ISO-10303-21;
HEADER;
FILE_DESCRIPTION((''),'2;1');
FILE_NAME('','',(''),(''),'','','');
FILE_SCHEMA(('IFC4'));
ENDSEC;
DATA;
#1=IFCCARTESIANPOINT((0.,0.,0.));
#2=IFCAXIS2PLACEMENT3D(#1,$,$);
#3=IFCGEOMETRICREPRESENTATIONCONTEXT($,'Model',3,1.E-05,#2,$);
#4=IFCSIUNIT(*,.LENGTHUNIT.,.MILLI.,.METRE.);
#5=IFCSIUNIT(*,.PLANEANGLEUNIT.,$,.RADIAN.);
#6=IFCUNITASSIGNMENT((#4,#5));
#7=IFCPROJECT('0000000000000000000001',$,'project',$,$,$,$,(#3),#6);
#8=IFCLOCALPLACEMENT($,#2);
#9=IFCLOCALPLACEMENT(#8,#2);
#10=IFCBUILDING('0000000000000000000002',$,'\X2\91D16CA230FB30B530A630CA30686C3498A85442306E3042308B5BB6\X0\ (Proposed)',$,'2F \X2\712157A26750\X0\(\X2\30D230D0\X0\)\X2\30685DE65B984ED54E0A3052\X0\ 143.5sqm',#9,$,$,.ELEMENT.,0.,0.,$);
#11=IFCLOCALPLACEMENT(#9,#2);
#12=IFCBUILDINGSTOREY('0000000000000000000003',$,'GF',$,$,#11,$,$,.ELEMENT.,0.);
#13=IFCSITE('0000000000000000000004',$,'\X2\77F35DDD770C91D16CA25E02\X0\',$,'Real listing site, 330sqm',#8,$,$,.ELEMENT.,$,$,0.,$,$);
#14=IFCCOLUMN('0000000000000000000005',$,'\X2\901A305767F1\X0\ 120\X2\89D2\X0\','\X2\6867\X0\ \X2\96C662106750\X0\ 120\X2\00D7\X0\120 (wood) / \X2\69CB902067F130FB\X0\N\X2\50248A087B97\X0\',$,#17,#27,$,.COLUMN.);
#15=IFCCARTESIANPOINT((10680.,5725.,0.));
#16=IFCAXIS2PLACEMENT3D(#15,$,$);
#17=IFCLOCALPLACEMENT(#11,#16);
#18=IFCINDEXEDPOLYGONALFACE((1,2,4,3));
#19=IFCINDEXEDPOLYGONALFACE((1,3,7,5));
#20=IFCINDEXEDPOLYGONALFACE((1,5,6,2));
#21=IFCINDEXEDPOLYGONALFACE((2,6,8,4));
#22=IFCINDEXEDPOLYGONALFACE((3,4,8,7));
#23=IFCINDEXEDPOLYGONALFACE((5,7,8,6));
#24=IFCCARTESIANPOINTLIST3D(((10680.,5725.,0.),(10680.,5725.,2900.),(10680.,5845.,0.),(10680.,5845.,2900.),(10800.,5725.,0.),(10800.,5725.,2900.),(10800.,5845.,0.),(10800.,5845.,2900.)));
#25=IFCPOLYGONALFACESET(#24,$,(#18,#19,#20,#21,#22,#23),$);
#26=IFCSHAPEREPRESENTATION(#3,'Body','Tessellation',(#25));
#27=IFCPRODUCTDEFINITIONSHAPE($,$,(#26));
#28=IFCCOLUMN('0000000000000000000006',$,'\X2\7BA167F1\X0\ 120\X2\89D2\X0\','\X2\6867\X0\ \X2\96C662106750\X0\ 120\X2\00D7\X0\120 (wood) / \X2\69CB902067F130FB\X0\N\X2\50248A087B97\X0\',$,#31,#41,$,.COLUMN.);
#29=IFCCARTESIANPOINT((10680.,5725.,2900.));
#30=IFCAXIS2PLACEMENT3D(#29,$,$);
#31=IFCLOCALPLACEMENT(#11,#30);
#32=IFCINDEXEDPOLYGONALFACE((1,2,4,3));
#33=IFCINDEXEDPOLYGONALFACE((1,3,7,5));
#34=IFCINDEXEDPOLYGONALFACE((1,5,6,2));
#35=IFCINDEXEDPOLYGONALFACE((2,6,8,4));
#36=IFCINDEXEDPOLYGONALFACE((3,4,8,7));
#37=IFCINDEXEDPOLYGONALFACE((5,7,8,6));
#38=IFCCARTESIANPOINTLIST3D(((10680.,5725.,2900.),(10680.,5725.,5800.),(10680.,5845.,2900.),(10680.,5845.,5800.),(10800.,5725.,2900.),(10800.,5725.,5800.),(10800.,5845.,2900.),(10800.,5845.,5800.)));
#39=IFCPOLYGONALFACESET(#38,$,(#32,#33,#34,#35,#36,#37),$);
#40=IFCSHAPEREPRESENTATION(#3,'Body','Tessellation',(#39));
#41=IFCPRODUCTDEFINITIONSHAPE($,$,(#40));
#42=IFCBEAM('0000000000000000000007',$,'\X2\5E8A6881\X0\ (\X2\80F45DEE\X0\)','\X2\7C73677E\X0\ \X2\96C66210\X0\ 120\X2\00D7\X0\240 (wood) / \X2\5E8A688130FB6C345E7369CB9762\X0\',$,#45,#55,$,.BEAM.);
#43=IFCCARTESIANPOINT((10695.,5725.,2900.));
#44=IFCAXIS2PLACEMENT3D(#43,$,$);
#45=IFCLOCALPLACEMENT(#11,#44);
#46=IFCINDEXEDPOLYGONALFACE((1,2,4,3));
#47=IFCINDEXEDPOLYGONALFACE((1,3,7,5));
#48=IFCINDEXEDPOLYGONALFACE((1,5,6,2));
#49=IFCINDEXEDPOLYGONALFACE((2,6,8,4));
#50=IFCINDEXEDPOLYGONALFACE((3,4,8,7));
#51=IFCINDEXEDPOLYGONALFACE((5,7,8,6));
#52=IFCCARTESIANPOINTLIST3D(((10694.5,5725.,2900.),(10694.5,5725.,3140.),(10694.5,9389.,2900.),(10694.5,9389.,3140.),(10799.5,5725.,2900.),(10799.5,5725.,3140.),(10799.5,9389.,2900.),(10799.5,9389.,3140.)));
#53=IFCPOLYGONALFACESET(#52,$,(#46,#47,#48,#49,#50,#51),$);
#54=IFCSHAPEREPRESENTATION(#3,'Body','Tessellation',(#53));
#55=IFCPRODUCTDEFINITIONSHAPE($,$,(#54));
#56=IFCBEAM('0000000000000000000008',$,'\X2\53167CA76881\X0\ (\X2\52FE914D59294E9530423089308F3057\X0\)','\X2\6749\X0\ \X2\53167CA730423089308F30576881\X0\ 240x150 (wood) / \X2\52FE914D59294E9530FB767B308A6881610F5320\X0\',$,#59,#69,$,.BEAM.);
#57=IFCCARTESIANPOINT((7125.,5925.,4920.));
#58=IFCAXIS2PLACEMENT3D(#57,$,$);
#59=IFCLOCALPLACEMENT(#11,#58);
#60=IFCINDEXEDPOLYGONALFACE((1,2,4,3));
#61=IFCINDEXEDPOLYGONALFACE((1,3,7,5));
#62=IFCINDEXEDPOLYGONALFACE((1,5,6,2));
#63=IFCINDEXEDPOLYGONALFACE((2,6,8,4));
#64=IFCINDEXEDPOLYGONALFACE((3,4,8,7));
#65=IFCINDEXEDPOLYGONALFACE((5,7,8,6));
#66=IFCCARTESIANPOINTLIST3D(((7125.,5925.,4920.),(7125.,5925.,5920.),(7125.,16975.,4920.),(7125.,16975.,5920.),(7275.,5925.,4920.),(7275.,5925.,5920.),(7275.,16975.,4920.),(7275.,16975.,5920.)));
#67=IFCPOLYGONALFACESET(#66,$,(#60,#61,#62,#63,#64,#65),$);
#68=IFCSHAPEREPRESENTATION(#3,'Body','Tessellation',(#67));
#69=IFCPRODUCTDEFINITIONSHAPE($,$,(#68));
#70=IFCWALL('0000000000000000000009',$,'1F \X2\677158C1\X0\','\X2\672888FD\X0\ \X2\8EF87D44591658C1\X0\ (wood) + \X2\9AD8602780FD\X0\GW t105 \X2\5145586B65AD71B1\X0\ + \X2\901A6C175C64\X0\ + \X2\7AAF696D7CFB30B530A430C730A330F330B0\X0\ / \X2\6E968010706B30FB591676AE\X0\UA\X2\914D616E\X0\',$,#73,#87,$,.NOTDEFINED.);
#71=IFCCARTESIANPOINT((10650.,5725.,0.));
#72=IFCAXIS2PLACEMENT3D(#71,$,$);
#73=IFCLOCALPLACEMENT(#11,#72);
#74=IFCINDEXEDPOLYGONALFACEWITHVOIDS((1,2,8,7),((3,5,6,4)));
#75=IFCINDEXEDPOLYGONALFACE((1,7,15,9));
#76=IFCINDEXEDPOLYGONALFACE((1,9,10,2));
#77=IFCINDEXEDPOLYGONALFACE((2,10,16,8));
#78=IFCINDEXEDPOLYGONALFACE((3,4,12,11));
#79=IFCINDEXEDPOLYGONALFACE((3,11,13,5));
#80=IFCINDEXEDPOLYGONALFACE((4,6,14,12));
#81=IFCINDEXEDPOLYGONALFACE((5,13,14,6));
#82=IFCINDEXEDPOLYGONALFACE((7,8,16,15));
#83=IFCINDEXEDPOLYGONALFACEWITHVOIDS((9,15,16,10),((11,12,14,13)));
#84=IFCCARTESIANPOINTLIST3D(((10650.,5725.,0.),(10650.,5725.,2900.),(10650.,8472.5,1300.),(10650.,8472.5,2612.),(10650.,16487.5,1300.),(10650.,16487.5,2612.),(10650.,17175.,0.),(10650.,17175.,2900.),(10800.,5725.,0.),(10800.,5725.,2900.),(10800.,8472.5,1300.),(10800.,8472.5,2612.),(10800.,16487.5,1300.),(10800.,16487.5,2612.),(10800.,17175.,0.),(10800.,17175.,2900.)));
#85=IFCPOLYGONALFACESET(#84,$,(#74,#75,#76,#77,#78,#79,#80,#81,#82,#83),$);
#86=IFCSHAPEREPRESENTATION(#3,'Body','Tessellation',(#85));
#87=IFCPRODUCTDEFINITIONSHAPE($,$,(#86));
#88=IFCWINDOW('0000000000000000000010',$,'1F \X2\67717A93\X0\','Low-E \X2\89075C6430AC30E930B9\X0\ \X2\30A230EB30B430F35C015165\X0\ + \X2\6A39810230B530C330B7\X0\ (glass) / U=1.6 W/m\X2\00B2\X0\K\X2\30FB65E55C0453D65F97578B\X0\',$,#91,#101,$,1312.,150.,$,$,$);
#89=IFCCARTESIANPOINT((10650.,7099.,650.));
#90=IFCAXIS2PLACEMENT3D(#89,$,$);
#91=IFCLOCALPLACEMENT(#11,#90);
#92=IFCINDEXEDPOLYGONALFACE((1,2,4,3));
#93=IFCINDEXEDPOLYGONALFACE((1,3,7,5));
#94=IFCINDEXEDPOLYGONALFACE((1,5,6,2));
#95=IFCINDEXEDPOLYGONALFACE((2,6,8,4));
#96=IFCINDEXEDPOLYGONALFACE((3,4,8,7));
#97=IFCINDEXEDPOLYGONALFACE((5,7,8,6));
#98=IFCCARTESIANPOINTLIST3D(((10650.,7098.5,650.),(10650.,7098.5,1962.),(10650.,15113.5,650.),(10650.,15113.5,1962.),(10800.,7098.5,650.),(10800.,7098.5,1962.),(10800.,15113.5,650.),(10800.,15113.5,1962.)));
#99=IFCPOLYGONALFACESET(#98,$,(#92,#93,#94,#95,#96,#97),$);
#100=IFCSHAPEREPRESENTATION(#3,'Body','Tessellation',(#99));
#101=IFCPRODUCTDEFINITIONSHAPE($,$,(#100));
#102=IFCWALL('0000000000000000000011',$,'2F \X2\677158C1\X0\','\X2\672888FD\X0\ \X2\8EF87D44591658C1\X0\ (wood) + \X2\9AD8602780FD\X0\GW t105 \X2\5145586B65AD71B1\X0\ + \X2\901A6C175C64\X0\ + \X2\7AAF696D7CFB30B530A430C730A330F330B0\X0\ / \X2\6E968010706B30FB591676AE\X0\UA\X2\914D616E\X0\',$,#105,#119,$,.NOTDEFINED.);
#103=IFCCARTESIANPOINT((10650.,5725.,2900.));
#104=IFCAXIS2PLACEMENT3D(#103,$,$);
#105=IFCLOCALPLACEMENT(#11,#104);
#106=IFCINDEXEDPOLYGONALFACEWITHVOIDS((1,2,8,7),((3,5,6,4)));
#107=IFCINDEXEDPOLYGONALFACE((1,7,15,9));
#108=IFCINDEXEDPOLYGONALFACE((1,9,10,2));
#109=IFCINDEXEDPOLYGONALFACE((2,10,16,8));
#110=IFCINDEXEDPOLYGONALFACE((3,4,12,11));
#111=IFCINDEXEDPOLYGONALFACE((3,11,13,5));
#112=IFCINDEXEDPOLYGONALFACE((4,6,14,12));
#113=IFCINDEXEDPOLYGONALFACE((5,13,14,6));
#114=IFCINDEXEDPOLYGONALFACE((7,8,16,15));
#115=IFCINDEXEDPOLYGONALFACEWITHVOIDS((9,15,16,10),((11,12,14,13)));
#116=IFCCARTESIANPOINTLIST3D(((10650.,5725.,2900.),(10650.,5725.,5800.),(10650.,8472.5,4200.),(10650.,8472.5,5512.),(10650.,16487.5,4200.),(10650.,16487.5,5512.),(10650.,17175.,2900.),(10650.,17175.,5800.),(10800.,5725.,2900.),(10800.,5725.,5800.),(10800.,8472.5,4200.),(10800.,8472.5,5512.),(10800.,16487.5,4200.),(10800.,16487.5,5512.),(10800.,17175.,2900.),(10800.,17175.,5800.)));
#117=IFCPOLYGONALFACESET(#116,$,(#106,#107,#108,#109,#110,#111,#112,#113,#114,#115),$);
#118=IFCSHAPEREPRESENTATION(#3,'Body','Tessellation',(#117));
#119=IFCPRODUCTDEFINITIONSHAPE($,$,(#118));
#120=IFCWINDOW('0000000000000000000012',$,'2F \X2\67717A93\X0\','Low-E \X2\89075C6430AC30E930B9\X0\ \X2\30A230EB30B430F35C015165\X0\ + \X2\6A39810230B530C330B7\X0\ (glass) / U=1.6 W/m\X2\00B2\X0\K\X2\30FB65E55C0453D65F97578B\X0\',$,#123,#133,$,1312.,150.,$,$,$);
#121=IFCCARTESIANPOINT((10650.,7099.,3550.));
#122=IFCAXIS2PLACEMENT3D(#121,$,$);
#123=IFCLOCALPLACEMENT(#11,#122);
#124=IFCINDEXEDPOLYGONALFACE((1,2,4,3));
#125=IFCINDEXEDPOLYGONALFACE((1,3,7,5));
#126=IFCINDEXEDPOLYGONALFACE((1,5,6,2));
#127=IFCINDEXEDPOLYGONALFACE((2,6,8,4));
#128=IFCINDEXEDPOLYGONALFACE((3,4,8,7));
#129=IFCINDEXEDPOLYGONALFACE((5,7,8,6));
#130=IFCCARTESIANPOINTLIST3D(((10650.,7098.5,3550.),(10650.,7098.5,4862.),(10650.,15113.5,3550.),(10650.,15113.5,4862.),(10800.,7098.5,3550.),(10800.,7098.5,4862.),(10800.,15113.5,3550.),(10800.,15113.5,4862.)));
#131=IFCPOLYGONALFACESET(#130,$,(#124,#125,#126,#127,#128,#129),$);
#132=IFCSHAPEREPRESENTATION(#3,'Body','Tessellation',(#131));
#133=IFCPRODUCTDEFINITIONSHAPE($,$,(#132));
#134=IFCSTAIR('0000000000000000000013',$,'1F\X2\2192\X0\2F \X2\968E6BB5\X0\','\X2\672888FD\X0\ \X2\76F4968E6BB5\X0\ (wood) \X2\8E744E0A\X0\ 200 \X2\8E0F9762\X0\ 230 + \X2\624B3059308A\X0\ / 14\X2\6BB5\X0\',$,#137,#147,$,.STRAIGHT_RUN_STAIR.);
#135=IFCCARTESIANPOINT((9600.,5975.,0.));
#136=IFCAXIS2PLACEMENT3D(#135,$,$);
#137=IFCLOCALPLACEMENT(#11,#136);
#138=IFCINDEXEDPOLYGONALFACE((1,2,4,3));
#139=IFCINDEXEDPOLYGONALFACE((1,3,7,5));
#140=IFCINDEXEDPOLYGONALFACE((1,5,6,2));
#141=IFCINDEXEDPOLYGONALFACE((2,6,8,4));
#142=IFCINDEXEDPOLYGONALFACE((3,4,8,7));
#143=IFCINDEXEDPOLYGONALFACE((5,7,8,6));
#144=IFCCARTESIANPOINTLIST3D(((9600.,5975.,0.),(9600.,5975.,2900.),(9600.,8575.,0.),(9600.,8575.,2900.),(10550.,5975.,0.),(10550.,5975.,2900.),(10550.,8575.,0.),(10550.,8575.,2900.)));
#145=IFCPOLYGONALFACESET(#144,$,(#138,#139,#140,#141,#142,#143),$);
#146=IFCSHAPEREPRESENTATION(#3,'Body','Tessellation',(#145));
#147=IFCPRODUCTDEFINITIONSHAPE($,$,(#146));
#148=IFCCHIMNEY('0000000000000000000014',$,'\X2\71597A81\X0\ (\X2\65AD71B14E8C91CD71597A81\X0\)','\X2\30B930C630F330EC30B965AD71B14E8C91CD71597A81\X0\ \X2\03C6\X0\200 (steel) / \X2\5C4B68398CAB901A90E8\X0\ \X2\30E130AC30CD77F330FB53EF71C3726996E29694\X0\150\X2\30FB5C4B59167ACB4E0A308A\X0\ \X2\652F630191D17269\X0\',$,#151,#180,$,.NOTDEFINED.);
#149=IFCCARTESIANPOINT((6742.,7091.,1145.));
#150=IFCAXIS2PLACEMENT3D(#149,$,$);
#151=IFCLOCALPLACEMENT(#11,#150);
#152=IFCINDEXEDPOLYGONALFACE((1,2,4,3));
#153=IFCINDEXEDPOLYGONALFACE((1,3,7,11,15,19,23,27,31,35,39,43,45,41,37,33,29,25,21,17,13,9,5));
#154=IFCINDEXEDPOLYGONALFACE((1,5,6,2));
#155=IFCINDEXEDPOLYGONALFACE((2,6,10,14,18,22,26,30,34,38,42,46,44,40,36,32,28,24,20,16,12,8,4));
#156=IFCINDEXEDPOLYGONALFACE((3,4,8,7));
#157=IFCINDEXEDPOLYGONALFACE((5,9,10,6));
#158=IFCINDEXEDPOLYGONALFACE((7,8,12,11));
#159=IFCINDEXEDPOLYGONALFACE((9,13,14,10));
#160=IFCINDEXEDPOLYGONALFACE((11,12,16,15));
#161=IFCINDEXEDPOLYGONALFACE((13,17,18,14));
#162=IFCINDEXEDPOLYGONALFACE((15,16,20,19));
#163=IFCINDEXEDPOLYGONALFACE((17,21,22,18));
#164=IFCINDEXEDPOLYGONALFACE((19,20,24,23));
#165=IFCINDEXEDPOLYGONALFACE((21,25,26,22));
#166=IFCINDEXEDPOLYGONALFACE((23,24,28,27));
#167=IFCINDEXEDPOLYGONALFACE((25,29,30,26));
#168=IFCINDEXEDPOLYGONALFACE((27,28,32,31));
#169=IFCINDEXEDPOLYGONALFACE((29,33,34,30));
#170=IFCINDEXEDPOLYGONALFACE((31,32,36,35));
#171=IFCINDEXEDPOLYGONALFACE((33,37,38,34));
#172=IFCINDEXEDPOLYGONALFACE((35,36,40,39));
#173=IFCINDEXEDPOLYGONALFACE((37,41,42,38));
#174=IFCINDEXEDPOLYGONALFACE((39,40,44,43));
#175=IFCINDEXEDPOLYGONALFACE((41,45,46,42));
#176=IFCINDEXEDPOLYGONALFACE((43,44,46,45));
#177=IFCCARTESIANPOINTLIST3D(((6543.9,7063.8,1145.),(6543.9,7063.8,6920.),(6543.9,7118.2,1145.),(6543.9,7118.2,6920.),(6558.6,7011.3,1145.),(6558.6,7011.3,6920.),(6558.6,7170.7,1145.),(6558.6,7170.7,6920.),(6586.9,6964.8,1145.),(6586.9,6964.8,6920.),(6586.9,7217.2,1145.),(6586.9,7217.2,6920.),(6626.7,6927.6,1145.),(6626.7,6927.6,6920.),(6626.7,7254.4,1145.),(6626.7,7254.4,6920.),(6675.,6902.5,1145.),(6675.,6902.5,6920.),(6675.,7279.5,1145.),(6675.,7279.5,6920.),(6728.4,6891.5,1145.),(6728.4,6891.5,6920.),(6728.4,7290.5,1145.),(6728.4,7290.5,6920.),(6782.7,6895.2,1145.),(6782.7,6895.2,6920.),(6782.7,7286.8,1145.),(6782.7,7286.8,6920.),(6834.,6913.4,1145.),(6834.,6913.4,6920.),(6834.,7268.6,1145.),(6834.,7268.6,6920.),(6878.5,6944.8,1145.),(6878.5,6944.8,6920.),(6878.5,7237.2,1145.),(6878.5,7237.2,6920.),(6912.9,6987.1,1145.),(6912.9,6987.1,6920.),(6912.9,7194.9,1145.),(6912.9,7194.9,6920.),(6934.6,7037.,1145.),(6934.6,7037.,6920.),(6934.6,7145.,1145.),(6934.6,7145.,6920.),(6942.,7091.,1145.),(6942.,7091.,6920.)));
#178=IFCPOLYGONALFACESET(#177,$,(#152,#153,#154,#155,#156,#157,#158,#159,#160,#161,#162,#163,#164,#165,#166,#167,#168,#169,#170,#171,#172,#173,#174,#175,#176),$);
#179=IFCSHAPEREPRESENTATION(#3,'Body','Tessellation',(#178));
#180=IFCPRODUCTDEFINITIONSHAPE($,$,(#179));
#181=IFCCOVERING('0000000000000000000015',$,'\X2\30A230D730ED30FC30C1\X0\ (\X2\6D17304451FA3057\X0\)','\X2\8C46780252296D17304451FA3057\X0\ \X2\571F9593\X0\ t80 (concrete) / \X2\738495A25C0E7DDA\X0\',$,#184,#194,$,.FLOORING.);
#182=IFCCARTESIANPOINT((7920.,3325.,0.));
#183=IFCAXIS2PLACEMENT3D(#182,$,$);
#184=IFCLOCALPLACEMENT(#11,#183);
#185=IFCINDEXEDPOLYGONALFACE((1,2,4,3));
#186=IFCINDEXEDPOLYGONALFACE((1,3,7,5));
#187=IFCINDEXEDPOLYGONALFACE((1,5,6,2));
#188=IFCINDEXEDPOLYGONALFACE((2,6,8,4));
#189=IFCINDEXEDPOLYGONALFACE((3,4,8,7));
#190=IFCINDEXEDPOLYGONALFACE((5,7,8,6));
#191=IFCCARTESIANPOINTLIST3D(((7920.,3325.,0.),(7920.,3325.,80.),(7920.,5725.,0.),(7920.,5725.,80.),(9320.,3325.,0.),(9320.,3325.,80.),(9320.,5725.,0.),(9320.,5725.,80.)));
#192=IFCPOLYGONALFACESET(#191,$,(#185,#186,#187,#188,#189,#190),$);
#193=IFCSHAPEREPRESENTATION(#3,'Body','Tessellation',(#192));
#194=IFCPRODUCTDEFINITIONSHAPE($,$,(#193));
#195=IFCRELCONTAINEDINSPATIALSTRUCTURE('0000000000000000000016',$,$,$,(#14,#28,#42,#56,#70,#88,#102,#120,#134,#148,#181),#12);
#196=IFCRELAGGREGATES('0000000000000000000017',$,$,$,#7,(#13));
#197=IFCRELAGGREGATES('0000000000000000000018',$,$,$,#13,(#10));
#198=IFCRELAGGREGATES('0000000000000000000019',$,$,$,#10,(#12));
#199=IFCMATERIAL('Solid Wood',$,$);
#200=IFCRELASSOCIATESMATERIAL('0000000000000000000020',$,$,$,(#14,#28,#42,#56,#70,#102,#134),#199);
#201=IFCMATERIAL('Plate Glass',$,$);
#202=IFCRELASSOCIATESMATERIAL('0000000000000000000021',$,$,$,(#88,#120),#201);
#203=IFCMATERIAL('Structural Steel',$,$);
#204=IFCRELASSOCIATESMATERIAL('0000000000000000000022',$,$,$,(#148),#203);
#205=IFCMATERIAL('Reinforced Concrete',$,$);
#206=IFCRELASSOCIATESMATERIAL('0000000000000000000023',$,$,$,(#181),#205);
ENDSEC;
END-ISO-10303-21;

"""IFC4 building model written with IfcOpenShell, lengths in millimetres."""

from ifc_helpers import new_model, si_unit, frame, frame_2d, origin, origin_2d, place, context, project, spatial, rectangle, circle, extrude, material, element, fill, save


model = new_model("IFC4")

# Units and contexts
model_context = context("Model", 3, precision=1e-05, world=origin())
ifc_project = project(units=[si_unit("LENGTHUNIT", "METRE", prefix="MILLI"), si_unit("PLANEANGLEUNIT", "RADIAN")], contexts=[model_context])

# Site, building, storey
site_placement = place(None, origin())
site = spatial("IfcSite", under=ifc_project, at=site_placement, Name="石川県金沢市", ObjectType="Real listing site, 330sqm", CompositionType="ELEMENT", RefElevation=0.0)
building_placement = place(site_placement, origin())
building = spatial("IfcBuilding", under=site, at=building_placement, Name="金沢・サウナと水風呂のある家 (Proposed)", ObjectType="2F 無垢材(ヒバ)と左官仕上げ 143.5sqm", CompositionType="ELEMENT", ElevationOfRefHeight=0.0, ElevationOfTerrain=0.0)
storey_placement = place(building_placement, origin())
storey = spatial("IfcBuildingStorey", under=building, at=storey_placement, Name="GF", CompositionType="ELEMENT", Elevation=0.0)

# Columns
ifc_material_1 = material(Name="Solid Wood")
column_1_placement = place(storey_placement, frame((10680.0, 5725.0, 0.0)))
element("IfcColumn", 1, at=column_1_placement, inside=storey, material=ifc_material_1, Name="通し柱 120角", Description="桧 集成材 120×120 (wood) / 構造柱・N値計算", PredefinedType="COLUMN", context=model_context, shape_type="SweptSolid", body=[
    extrude(rectangle(XDim=120.0, YDim=120.0, at=frame_2d((60.0, 60.0))), frame((10680.0, 5725.0, 0.0)), (0.0, 0.0, 1.0), 2900.0),
])
column_2_placement = place(storey_placement, frame((10680.0, 5725.0, 2900.0)))
element("IfcColumn", 2, at=column_2_placement, inside=storey, material=ifc_material_1, Name="管柱 120角", Description="桧 集成材 120×120 (wood) / 構造柱・N値計算", PredefinedType="COLUMN", context=model_context, shape_type="SweptSolid", body=[
    extrude(rectangle(XDim=120.0, YDim=120.0, at=frame_2d((60.0, 60.0))), frame((10680.0, 5725.0, 2900.0)), (0.0, 0.0, 1.0), 2900.0),
])

# Beams
beam_1_placement = place(storey_placement, frame((10695.0, 5725.0, 2900.0)))
element("IfcBeam", 3, at=beam_1_placement, inside=storey, material=ifc_material_1, Name="床梁 (胴差)", Description="米松 集成 120×240 (wood) / 床梁・水平構面", PredefinedType="BEAM", context=model_context, shape_type="SweptSolid", body=[
    extrude(rectangle(XDim=105.0, YDim=3664.0, at=frame_2d((52.0, 1832.0))), frame((10695.0, 5725.0, 2900.0)), (0.0, 0.0, 1.0), 240.0),
])
beam_2_placement = place(storey_placement, frame((7125.0, 5925.0, 4920.0)))
element("IfcBeam", 4, at=beam_2_placement, inside=storey, material=ifc_material_1, Name="化粧梁 (勾配天井あらわし)", Description="杉 化粧あらわし梁 240x150 (wood) / 勾配天井・登り梁意匠", PredefinedType="BEAM", context=model_context, shape_type="SweptSolid", body=[
    extrude(rectangle(XDim=150.0, YDim=11050.0, at=frame_2d((75.0, 5525.0))), frame((7125.0, 5925.0, 4920.0)), (0.0, 0.0, 1.0), 1000.0),
])

# Wall, opening, window
wall_1_placement = place(storey_placement, frame((10650.0, 5725.0, 0.0)))
wall_1 = element("IfcWall", 5, at=wall_1_placement, inside=storey, material=ifc_material_1, Name="1F 東壁", Description="木製 軸組外壁 (wood) + 高性能GW t105 充填断熱 + 通気層 + 窯業系サイディング / 準耐火・外皮UA配慮", PredefinedType="NOTDEFINED", context=model_context, shape_type="SweptSolid", body=[
    extrude(rectangle(XDim=150.0, YDim=11450.0, at=frame_2d((75.0, 5725.0))), frame((10650.0, 5725.0, 0.0)), (0.0, 0.0, 1.0), 2900.0),
])
opening_1_placement = place(storey_placement, frame((10650.0, 7099.0, 650.0)))
opening_1 = element("IfcOpeningElement", 6, at=opening_1_placement, cuts=wall_1, PredefinedType="NOTDEFINED", context=model_context, shape_type="SweptSolid", body=[
    extrude(rectangle(XDim=150.0, YDim=8015.0, at=frame_2d((75.0, 4007.0))), frame((10650.0, 7099.0, 650.0)), (0.0, 0.0, 1.0), 1312.0),
])
ifc_material_2 = material(Name="Plate Glass")
window_1_placement = place(storey_placement, frame((10650.0, 7099.0, 650.0)))
window_1 = element("IfcWindow", 7, at=window_1_placement, inside=storey, material=ifc_material_2, Name="1F 東窓", Description="Low-E 複層ガラス アルゴン封入 + 樹脂サッシ (glass) / U=1.6 W/m²K・日射取得型", OverallHeight=1312.0, OverallWidth=150.0, context=model_context, shape_type="SweptSolid", body=[
    extrude(rectangle(XDim=150.0, YDim=8015.0, at=frame_2d((75.0, 4007.0))), frame((10650.0, 7099.0, 650.0)), (0.0, 0.0, 1.0), 1312.0),
])
fill(opening_1, window_1)

# Wall, opening, window
wall_2_placement = place(storey_placement, frame((10650.0, 5725.0, 2900.0)))
wall_2 = element("IfcWall", 8, at=wall_2_placement, inside=storey, material=ifc_material_1, Name="2F 東壁", Description="木製 軸組外壁 (wood) + 高性能GW t105 充填断熱 + 通気層 + 窯業系サイディング / 準耐火・外皮UA配慮", PredefinedType="NOTDEFINED", context=model_context, shape_type="SweptSolid", body=[
    extrude(rectangle(XDim=150.0, YDim=11450.0, at=frame_2d((75.0, 5725.0))), frame((10650.0, 5725.0, 2900.0)), (0.0, 0.0, 1.0), 2900.0),
])
opening_2_placement = place(storey_placement, frame((10650.0, 7099.0, 3550.0)))
opening_2 = element("IfcOpeningElement", 9, at=opening_2_placement, cuts=wall_2, PredefinedType="NOTDEFINED", context=model_context, shape_type="SweptSolid", body=[
    extrude(rectangle(XDim=150.0, YDim=8015.0, at=frame_2d((75.0, 4007.0))), frame((10650.0, 7099.0, 3550.0)), (0.0, 0.0, 1.0), 1312.0),
])
window_2_placement = place(storey_placement, frame((10650.0, 7099.0, 3550.0)))
window_2 = element("IfcWindow", 10, at=window_2_placement, inside=storey, material=ifc_material_2, Name="2F 東窓", Description="Low-E 複層ガラス アルゴン封入 + 樹脂サッシ (glass) / U=1.6 W/m²K・日射取得型", OverallHeight=1312.0, OverallWidth=150.0, context=model_context, shape_type="SweptSolid", body=[
    extrude(rectangle(XDim=150.0, YDim=8015.0, at=frame_2d((75.0, 4007.0))), frame((10650.0, 7099.0, 3550.0)), (0.0, 0.0, 1.0), 1312.0),
])
fill(opening_2, window_2)

# Stair
stair_placement = place(storey_placement, frame((9600.0, 5975.0, 0.0)))
element("IfcStair", 11, at=stair_placement, inside=storey, material=ifc_material_1, Name="1F→2F 階段", Description="木製 直階段 (wood) 蹴上 200 踏面 230 + 手すり / 14段", PredefinedType="STRAIGHT_RUN_STAIR", context=model_context, shape_type="SweptSolid", body=[
    extrude(rectangle(XDim=950.0, YDim=2600.0, at=frame_2d((475.0, 1300.0))), frame((9600.0, 5975.0, 0.0)), (0.0, 0.0, 1.0), 2900.0),
])

# Chimney
ifc_material_3 = material(Name="Structural Steel")
chimney_placement = place(storey_placement, frame((6742.0, 7091.0, 1145.0)))
element("IfcChimney", 12, at=chimney_placement, inside=storey, material=ifc_material_3, Name="煙突 (断熱二重煙突)", Description="ステンレス断熱二重煙突 φ200 (steel) / 屋根貫通部 メガネ石・可燃物離隔150・屋外立上り 支持金物", PredefinedType="NOTDEFINED", context=model_context, shape_type="SweptSolid", body=[
    extrude(circle(Radius=200.0, at=origin_2d()), frame((6742.0, 7091.0, 1145.0)), (0.0, 0.0, 1.0), 5775.0),
])

# Covering
ifc_material_4 = material(Name="Reinforced Concrete")
covering_1_placement = place(storey_placement, frame((7920.0, 3325.0, 0.0)))
element("IfcCovering", 13, at=covering_1_placement, inside=storey, material=ifc_material_4, Name="アプローチ (洗い出し)", Description="豆砂利洗い出し 土間 t80 (concrete) / 玄関導線", PredefinedType="FLOORING", context=model_context, shape_type="SweptSolid", body=[
    extrude(rectangle(XDim=1400.0, YDim=2400.0, at=frame_2d((700.0, 1200.0))), frame((7920.0, 3325.0, 0.0)), (0.0, 0.0, 1.0), 80.0),
])

save(model, "model.ifc")
